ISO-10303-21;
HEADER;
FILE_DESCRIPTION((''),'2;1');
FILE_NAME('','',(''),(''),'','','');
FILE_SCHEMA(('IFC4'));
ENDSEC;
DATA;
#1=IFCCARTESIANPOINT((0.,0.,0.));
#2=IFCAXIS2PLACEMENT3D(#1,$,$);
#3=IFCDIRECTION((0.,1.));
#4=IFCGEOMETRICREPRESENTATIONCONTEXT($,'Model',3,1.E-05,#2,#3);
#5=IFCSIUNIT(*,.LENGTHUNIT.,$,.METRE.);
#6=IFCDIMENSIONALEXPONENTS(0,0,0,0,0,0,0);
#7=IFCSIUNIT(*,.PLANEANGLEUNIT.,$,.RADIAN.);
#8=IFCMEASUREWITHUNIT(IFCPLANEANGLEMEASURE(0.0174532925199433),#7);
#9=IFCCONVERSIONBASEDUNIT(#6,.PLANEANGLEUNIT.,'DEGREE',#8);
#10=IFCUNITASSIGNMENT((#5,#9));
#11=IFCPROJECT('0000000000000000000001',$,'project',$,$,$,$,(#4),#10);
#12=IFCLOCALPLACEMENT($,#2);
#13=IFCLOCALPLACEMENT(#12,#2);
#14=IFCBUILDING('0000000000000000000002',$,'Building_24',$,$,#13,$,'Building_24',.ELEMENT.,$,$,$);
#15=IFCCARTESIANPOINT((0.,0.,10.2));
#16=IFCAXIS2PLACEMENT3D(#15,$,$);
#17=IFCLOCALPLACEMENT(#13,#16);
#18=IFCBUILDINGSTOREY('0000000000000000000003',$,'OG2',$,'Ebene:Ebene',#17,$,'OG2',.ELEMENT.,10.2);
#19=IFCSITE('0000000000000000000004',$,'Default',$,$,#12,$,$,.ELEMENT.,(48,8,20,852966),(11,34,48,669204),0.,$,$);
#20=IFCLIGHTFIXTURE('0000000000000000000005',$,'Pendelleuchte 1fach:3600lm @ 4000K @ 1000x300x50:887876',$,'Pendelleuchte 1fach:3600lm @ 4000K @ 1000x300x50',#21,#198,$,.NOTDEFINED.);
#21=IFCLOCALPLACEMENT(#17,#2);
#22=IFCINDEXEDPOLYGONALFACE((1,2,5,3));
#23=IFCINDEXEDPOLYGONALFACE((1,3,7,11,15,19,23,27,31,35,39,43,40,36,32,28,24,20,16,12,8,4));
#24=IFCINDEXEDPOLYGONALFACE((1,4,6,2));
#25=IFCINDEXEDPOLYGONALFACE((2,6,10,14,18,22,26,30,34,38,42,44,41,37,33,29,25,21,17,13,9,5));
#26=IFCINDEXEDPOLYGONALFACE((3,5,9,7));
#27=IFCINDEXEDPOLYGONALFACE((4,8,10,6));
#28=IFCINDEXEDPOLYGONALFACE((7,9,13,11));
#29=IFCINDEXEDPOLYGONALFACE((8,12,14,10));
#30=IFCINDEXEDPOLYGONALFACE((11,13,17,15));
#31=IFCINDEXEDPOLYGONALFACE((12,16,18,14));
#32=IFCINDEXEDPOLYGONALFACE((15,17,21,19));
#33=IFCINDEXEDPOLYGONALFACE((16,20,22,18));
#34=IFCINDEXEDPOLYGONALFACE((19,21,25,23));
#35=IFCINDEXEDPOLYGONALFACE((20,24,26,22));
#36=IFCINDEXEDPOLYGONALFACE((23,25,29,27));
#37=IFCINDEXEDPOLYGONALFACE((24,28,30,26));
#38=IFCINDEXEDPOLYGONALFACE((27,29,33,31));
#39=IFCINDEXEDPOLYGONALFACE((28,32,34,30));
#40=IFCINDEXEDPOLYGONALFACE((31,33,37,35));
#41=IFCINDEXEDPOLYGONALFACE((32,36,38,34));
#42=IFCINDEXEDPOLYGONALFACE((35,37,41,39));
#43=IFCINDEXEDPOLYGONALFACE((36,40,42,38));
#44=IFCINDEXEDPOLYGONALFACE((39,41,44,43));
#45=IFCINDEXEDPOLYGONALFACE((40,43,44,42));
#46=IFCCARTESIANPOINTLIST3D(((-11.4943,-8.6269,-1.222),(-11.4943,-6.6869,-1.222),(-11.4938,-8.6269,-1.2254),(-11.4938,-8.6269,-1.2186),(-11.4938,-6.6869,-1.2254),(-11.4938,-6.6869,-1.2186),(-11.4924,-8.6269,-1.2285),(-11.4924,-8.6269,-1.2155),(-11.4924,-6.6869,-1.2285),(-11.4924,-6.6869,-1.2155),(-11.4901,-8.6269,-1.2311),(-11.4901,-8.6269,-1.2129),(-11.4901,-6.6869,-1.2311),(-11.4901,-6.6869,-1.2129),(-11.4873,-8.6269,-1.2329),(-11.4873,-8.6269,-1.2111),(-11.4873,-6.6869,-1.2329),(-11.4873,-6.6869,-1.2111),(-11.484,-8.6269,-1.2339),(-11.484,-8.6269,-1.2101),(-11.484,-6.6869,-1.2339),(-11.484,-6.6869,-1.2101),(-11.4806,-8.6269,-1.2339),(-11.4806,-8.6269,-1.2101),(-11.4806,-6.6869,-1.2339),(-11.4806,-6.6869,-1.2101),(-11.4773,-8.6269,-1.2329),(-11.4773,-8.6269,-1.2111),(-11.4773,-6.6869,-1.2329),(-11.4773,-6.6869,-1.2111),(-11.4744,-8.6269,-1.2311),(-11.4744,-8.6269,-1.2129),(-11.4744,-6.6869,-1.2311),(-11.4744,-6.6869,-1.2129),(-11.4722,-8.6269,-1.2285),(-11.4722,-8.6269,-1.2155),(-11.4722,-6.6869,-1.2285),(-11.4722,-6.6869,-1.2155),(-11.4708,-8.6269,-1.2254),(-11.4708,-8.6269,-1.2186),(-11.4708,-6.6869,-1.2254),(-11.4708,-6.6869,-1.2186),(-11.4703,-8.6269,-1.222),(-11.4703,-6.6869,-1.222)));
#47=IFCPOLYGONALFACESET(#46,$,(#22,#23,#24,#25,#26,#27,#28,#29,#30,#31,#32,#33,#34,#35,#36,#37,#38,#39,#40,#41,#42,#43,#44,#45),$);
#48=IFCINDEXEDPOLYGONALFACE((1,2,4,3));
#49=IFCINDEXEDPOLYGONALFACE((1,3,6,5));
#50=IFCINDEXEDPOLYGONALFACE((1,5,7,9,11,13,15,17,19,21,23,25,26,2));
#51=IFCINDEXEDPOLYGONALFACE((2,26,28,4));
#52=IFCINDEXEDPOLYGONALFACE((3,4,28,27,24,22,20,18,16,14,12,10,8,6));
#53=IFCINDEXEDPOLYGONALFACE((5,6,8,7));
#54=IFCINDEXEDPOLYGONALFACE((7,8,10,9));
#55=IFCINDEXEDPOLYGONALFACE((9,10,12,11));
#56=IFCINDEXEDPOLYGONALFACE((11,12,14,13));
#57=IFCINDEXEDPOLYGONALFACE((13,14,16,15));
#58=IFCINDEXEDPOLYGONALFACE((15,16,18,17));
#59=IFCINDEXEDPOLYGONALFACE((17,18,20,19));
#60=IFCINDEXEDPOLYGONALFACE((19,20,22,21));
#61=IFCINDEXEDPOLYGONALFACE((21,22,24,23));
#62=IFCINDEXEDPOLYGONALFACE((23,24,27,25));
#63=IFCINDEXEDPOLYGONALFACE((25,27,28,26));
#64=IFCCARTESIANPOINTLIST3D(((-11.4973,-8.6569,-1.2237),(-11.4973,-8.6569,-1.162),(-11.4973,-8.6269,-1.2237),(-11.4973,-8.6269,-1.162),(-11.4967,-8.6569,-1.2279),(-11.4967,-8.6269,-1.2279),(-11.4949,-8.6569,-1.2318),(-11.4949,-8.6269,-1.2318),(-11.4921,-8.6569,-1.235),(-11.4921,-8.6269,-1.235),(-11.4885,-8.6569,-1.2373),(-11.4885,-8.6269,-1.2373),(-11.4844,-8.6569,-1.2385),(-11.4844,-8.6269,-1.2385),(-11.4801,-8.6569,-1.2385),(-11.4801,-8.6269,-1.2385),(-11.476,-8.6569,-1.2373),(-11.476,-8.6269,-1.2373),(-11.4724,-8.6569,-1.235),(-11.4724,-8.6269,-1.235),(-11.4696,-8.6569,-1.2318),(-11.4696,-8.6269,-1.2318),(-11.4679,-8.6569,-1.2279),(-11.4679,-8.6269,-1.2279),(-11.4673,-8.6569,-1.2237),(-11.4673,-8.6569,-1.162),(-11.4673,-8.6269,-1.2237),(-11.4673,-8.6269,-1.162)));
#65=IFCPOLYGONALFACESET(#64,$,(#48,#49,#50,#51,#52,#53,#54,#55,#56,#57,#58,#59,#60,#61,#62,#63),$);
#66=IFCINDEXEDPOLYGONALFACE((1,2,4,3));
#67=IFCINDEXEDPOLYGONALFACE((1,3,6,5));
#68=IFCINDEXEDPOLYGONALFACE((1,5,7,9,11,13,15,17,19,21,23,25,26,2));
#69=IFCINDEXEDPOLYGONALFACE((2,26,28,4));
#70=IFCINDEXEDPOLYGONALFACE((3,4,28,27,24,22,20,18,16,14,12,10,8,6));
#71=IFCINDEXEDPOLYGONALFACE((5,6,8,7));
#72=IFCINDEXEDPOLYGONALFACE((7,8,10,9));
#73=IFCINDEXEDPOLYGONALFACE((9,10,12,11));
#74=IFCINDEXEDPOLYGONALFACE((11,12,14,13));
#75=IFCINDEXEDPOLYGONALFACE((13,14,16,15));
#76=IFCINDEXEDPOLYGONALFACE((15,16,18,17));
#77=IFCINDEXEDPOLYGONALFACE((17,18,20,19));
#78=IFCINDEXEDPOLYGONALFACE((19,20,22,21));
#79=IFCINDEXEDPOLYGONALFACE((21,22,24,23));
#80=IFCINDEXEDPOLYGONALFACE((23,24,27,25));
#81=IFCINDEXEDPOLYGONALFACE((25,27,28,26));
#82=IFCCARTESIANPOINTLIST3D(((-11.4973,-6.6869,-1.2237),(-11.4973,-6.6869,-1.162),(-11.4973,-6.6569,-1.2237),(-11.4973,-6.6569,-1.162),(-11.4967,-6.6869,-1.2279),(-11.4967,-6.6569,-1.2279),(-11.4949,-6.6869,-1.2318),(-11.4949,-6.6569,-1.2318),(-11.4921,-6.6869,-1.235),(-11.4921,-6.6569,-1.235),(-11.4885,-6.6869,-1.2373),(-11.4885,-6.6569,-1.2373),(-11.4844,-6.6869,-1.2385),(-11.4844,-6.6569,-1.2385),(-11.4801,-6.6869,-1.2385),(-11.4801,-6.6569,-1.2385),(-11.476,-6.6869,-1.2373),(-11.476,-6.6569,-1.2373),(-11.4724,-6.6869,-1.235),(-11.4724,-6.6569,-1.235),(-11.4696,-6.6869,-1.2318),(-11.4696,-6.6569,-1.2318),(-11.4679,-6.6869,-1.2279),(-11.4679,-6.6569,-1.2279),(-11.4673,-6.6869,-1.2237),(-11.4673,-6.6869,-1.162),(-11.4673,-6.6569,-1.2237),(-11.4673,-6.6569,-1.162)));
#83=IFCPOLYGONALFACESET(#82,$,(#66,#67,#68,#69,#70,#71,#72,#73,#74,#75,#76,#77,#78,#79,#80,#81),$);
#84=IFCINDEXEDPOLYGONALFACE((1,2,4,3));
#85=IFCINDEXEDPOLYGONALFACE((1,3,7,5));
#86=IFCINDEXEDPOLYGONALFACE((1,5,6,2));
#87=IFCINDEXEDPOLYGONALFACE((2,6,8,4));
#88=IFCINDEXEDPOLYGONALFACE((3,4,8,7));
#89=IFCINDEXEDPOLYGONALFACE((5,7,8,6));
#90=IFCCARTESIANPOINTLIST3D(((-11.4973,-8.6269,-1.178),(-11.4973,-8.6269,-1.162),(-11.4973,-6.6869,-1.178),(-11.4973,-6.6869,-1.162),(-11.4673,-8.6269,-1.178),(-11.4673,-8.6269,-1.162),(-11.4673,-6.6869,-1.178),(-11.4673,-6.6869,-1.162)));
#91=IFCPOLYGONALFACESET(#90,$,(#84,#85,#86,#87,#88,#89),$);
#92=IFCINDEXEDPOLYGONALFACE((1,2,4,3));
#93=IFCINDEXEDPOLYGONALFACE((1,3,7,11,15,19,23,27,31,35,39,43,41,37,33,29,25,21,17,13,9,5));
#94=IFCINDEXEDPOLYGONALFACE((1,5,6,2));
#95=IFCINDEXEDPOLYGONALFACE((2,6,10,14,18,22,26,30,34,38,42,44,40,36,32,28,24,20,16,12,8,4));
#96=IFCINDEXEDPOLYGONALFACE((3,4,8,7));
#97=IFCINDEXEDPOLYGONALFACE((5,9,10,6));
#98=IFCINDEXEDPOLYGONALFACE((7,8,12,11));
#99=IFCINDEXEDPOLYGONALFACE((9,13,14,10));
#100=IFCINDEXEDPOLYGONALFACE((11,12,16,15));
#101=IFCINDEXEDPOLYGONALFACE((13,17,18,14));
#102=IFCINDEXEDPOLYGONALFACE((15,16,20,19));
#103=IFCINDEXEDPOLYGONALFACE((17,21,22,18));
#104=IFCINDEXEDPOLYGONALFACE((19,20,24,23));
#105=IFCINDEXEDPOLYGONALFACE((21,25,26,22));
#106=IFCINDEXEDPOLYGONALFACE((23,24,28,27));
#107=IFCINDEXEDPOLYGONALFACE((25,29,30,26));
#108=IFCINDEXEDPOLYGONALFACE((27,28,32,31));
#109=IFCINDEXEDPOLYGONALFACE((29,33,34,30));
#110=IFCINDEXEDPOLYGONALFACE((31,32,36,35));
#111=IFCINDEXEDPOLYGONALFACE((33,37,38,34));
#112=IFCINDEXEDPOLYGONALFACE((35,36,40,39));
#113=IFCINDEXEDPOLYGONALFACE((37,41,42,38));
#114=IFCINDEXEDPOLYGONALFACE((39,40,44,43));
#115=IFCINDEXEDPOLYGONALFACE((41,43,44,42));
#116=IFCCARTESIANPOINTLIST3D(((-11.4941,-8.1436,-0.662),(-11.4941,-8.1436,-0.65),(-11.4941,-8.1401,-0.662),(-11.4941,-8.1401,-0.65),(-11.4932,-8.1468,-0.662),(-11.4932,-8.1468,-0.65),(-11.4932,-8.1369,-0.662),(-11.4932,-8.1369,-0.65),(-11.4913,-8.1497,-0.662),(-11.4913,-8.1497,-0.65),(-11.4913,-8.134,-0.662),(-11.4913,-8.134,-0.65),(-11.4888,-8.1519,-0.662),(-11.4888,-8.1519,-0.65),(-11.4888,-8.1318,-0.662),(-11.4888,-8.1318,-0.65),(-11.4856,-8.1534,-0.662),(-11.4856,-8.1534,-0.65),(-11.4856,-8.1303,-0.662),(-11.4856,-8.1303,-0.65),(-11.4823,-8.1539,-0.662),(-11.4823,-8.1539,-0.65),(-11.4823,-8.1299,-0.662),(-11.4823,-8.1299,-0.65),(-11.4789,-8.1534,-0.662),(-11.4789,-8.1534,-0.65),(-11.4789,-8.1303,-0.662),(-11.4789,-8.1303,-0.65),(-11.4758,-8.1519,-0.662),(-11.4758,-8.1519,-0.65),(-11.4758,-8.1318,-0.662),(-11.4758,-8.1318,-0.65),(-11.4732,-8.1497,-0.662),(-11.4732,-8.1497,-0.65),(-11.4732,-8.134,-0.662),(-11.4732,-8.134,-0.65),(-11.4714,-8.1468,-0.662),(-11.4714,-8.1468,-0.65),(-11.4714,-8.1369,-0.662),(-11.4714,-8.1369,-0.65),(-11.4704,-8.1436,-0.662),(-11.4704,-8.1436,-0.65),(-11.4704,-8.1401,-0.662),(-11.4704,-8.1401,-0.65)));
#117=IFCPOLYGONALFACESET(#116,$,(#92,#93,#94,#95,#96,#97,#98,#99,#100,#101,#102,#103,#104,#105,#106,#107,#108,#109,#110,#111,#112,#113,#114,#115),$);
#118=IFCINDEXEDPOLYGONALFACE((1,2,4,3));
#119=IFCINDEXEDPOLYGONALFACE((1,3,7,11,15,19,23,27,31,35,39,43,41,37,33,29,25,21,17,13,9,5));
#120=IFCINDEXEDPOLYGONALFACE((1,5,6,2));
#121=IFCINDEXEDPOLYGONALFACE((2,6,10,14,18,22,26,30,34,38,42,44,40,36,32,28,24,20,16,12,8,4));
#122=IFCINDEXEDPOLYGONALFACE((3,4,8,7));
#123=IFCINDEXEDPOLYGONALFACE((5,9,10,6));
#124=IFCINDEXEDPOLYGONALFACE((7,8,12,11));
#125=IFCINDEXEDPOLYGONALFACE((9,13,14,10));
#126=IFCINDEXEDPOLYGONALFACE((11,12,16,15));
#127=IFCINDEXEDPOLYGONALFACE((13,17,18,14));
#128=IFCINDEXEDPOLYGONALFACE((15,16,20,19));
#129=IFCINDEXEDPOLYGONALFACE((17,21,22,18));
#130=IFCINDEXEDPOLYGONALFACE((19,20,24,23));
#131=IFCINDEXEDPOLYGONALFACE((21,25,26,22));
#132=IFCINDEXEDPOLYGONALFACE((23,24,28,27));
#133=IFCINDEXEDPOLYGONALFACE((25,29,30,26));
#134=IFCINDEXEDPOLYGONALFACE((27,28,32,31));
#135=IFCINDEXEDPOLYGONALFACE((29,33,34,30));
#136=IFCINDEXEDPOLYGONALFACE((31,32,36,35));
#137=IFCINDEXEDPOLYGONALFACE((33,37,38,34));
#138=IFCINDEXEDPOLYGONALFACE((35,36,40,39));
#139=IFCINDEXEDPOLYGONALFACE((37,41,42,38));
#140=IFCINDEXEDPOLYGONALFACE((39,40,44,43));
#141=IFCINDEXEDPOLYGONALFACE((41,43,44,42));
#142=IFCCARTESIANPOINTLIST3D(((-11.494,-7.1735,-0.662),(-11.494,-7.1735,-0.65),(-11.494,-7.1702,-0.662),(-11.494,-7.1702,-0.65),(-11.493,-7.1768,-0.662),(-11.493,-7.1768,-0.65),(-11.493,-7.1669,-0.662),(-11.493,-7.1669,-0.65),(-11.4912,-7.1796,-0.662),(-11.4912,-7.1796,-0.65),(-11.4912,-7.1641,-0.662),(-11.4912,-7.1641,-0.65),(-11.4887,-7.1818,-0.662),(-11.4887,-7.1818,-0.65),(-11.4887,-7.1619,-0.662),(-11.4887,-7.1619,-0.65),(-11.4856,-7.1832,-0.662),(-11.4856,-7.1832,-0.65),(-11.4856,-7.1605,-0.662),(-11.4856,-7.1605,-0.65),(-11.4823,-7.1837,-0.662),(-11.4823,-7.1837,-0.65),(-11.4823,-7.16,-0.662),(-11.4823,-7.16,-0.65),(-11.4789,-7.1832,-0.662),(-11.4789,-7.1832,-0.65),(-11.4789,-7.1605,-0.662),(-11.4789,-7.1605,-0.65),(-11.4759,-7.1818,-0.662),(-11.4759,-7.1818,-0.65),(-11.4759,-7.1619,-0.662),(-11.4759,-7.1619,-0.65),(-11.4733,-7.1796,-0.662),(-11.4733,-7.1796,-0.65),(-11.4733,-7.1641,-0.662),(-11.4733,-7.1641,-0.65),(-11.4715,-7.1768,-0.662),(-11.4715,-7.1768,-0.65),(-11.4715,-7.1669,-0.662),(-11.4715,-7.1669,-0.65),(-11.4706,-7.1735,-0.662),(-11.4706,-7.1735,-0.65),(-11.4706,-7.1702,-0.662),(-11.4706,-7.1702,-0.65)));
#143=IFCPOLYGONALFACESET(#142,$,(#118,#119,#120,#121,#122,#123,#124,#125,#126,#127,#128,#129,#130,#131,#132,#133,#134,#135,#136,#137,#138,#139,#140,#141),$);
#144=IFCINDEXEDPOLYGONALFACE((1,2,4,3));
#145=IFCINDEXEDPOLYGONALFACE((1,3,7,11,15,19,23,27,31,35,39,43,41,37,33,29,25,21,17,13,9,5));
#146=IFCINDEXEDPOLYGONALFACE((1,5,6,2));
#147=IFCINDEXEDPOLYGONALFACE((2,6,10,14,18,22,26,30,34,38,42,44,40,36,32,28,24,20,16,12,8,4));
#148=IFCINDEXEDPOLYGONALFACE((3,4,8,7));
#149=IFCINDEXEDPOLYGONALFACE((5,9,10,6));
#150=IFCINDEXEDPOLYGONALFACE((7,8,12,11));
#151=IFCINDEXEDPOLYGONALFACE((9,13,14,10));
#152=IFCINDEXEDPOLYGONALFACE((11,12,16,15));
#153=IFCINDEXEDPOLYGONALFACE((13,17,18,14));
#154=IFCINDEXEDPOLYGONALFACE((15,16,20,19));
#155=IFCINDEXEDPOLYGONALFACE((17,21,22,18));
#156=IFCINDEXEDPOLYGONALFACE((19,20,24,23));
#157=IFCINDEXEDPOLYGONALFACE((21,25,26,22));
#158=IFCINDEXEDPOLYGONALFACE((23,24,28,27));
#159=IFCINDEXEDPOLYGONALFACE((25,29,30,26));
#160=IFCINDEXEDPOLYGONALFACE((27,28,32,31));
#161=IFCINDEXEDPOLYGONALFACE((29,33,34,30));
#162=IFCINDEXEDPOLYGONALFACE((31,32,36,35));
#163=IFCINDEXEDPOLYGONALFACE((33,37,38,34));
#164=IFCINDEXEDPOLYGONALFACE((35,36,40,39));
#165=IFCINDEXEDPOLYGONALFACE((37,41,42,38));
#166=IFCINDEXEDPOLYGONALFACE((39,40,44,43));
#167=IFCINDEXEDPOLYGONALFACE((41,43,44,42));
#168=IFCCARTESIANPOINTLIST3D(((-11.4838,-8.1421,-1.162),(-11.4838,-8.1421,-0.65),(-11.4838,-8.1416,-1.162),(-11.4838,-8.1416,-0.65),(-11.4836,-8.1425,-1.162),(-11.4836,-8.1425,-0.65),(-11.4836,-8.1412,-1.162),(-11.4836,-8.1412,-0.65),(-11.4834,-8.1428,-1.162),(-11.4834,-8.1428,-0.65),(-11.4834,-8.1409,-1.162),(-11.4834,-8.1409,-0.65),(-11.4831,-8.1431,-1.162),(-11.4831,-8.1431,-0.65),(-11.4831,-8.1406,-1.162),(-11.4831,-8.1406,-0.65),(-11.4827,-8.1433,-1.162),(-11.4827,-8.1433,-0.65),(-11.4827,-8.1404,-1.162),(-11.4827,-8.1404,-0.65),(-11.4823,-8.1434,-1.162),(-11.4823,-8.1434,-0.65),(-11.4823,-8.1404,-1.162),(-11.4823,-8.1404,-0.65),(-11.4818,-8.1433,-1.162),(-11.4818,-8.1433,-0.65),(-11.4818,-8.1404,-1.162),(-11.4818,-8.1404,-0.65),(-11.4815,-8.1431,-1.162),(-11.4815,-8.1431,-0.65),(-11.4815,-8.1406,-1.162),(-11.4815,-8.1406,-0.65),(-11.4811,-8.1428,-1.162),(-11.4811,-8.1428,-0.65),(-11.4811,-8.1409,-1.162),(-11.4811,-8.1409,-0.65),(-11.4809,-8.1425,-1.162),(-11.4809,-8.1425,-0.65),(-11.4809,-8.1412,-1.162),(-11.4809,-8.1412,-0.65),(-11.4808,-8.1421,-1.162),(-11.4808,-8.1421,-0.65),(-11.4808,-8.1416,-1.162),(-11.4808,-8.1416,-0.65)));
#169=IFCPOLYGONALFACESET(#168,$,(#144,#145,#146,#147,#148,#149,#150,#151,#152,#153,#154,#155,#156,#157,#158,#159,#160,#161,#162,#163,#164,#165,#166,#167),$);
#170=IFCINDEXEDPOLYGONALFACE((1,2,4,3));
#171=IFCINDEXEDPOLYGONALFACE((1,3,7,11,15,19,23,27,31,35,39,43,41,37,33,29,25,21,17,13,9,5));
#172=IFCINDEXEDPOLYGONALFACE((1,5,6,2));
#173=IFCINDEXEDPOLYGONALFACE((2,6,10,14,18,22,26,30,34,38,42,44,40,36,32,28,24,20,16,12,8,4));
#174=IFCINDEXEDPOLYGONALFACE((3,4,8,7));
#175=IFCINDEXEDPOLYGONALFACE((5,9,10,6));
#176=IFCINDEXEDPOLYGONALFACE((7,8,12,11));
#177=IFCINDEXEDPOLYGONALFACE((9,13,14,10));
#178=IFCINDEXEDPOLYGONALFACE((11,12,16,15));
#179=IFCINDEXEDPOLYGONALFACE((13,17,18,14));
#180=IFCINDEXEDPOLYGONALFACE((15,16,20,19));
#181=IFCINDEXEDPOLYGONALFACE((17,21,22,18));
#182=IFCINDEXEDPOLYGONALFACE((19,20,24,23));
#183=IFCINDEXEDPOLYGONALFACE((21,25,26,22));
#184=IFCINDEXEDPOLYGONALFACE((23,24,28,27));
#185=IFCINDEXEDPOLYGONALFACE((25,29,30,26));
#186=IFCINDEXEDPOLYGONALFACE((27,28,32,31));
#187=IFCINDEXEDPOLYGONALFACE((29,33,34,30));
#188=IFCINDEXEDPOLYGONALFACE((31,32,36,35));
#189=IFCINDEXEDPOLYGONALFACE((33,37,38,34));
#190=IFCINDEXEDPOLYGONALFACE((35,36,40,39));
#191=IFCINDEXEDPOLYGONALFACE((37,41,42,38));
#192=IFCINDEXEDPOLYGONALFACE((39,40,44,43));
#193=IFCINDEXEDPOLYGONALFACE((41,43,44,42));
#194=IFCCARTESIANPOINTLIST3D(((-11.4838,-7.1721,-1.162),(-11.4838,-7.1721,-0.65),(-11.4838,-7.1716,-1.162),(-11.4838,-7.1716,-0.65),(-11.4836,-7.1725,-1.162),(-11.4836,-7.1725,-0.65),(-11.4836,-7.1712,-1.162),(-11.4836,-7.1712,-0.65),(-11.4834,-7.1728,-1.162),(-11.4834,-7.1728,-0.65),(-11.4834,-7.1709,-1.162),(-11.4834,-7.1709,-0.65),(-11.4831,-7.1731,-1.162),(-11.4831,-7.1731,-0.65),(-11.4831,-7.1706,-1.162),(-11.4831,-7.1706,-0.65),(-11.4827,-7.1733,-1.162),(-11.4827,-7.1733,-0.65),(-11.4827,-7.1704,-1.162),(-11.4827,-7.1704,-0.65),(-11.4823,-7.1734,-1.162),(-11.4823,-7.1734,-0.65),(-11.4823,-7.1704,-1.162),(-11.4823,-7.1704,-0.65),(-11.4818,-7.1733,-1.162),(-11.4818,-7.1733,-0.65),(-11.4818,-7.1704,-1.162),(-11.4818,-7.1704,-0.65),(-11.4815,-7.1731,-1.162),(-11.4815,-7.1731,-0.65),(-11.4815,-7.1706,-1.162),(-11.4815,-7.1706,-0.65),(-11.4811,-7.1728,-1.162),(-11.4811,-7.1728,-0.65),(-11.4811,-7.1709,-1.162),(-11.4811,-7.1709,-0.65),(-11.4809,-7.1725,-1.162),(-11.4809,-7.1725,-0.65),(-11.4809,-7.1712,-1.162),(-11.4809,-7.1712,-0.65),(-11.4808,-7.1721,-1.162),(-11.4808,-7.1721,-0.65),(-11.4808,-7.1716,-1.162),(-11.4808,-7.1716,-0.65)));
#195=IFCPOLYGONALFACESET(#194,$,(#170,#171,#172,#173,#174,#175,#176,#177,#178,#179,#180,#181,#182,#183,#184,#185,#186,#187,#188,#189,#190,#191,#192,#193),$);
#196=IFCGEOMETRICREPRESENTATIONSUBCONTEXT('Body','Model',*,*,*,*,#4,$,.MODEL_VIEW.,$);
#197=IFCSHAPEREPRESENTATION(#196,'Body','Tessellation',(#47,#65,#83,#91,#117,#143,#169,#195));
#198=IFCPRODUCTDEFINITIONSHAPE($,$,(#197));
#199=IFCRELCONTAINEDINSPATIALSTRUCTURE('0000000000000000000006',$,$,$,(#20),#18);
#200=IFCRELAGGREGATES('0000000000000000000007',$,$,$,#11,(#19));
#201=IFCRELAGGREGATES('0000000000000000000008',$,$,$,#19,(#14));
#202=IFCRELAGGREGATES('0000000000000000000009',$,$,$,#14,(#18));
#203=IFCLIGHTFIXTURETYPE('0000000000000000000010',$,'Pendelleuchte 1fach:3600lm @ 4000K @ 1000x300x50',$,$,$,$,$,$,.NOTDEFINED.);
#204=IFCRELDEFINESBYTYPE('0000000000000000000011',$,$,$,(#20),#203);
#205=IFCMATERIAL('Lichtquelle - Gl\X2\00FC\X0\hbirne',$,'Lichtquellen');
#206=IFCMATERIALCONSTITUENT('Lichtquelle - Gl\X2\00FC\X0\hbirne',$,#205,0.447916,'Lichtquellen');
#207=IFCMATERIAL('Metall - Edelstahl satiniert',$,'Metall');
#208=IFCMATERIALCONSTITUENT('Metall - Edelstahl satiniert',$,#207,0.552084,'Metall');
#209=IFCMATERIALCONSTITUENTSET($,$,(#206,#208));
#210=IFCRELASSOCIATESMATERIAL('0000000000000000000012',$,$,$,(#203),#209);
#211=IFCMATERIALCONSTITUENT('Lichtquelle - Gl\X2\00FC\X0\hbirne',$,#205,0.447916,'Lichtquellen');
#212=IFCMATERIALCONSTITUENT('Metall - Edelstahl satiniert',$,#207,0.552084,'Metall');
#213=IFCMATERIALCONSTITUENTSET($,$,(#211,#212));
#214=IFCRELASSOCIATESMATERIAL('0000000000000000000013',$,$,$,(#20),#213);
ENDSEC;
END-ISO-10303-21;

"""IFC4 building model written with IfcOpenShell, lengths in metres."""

from ifc_helpers import new_model, entity, si_unit, converted_unit, direction, frame, origin, place, context, subcontext, project, spatial, line, arc, indexed_curve, outline, extrude, source, transform, mapped, material, constituent, constituent_set, type_object, type_shapes, element, save


model = new_model("IFC4")

# Units and contexts
model_context = context("Model", 3, precision=1e-05, world=origin(), true_north=direction((0.0, 1.0)))
body_context = subcontext(model_context, "Body", "Model", "MODEL_VIEW")
ifc_project = project(units=[si_unit("LENGTHUNIT", "METRE"), converted_unit("PLANEANGLEUNIT", "DEGREE", entity("IfcPlaneAngleMeasure", 0.0174532925199433), si_unit("PLANEANGLEUNIT", "RADIAN"), dimensions=[0, 0, 0, 0, 0, 0, 0])], contexts=[model_context])

# Site, building, storey
site_placement = place(None, origin())
site = spatial("IfcSite", under=ifc_project, at=site_placement, Name="Default", CompositionType="ELEMENT", RefLatitude=(48, 8, 20, 852966), RefLongitude=(11, 34, 48, 669204), RefElevation=0.0)
building_placement = place(site_placement, origin())
building = spatial("IfcBuilding", under=site, at=building_placement, Name="Building_24", LongName="Building_24", CompositionType="ELEMENT")
storey_placement = place(building_placement, frame((0.0, 0.0, 10.2)))
storey = spatial("IfcBuildingStorey", under=building, at=storey_placement, Name="OG2", ObjectType="Ebene:Ebene", LongName="OG2", CompositionType="ELEMENT", Elevation=10.2)

# Light fixture
ifc_material_1 = material(Name="Lichtquelle - Glühbirne", Category="Lichtquellen")
ifc_constituent_1 = constituent(ifc_material_1, Name="Lichtquelle - Glühbirne", Category="Lichtquellen", fraction=0.447916)
ifc_material_2 = material(Name="Metall - Edelstahl satiniert", Category="Metall")
ifc_constituent_2 = constituent(ifc_material_2, Name="Metall - Edelstahl satiniert", Category="Metall", fraction=0.552084)
ifc_constituent_set_1 = constituent_set(constituents=[ifc_constituent_1, ifc_constituent_2])
ifc_constituent_3 = constituent(ifc_material_1, Name="Lichtquelle - Glühbirne", Category="Lichtquellen", fraction=0.447916)
ifc_constituent_4 = constituent(ifc_material_2, Name="Metall - Edelstahl satiniert", Category="Metall", fraction=0.552084)
ifc_constituent_set_2 = constituent_set(constituents=[ifc_constituent_3, ifc_constituent_4])
light_fixture_type_1 = type_object("IfcLightFixtureType", Name="Pendelleuchte 1fach:3600lm @ 4000K @ 1000x300x50", PredefinedType="NOTDEFINED", material=ifc_constituent_set_2)
shared_shape_1 = source(origin(), body_context, "Body", "SweptSolid", [
    extrude(outline(indexed_curve([(-0.012, 0.0), (0.0, -0.012), (0.012, 0.0), (0.0, 0.012)], segments=[arc(1, 2, 3), arc(3, 4, 1)], self_intersect=False)), frame((-0.97, 0.0, -0.572), z_axis=(1.0, 0.0, 0.0), x_axis=(0.0, 1.0, 0.0)), (0.0, 0.0, 1.0), 1.94),
    extrude(outline(indexed_curve([(-0.0308, -0.015), (0.0308, -0.015), (0.0308, 0.015), (-0.0308, 0.015), (-0.0458, 0.0)], segments=[line(1, 2, 3, 4), arc(4, 5, 1)], self_intersect=False)), frame((0.97, 0.0, -0.5428), z_axis=(1.0, 0.0, 0.0), x_axis=(0.0, 0.0, 1.0)), (0.0, 0.0, 1.0), 0.03),
    extrude(outline(indexed_curve([(-0.0308, -0.015), (0.0308, -0.015), (0.0308, 0.015), (-0.0308, 0.015), (-0.0458, 0.0)], segments=[line(1, 2, 3, 4), arc(4, 5, 1)], self_intersect=False)), frame((-1.0, 0.0, -0.5428), z_axis=(1.0, 0.0, 0.0), x_axis=(0.0, 0.0, 1.0)), (0.0, 0.0, 1.0), 0.03),
    extrude(outline(indexed_curve([(-0.97, -0.015), (0.97, -0.015), (0.97, 0.015), (-0.97, 0.015), (-0.97, -0.015)], self_intersect=False)), frame((0.0, 0.0, -0.528), z_axis=(0.0, 0.0, 1.0), x_axis=(-1.0, 0.0, 0.0)), (0.0, 0.0, 1.0), 0.016),
    extrude(outline(indexed_curve([(-0.012, 0.0), (0.0, -0.012), (0.012, 0.0), (0.0, 0.012)], segments=[arc(1, 2, 3), arc(3, 4, 1)], self_intersect=False)), frame((0.485, 0.0, -0.012)), (0.0, 0.0, 1.0), 0.012),
    extrude(outline(indexed_curve([(-0.0118, 0.0), (0.0, -0.0118), (0.0118, 0.0), (0.0, 0.0118)], segments=[arc(1, 2, 3), arc(3, 4, 1)], self_intersect=False)), frame((-0.485, 0.0, -0.012)), (0.0, 0.0, 1.0), 0.012),
    extrude(outline(indexed_curve([(-0.0015, 0.0), (0.0, -0.0015), (0.0015, 0.0), (0.0, 0.0015)], segments=[arc(1, 2, 3), arc(3, 4, 1)], self_intersect=False)), frame((0.485, 0.0, -0.512)), (0.0, 0.0, 1.0), 0.512),
    extrude(outline(indexed_curve([(-0.0015, 0.0), (0.0, -0.0015), (0.0015, 0.0), (0.0, 0.0015)], segments=[arc(1, 2, 3), arc(3, 4, 1)], self_intersect=False)), frame((-0.485, 0.0, -0.512)), (0.0, 0.0, 1.0), 0.512),
])
type_shapes(light_fixture_type_1, [shared_shape_1])
light_fixture_1_placement = place(storey_placement, frame((-11.4823, -7.6569, -0.65), z_axis=(0.0, 0.0, 1.0), x_axis=(0.0, -1.0, 0.0)))
element("IfcLightFixture", 1, at=light_fixture_1_placement, inside=storey, type_object=light_fixture_type_1, material=ifc_constituent_set_1, Name="Pendelleuchte 1fach:3600lm @ 4000K @ 1000x300x50:887876", ObjectType="Pendelleuchte 1fach:3600lm @ 4000K @ 1000x300x50", PredefinedType="NOTDEFINED", context=body_context, shape_type="MappedRepresentation", body=[
    mapped(shared_shape_1, transform((0.0, 0.0, 0.0), scale=1.0)),
])

save(model, "model.ifc")
